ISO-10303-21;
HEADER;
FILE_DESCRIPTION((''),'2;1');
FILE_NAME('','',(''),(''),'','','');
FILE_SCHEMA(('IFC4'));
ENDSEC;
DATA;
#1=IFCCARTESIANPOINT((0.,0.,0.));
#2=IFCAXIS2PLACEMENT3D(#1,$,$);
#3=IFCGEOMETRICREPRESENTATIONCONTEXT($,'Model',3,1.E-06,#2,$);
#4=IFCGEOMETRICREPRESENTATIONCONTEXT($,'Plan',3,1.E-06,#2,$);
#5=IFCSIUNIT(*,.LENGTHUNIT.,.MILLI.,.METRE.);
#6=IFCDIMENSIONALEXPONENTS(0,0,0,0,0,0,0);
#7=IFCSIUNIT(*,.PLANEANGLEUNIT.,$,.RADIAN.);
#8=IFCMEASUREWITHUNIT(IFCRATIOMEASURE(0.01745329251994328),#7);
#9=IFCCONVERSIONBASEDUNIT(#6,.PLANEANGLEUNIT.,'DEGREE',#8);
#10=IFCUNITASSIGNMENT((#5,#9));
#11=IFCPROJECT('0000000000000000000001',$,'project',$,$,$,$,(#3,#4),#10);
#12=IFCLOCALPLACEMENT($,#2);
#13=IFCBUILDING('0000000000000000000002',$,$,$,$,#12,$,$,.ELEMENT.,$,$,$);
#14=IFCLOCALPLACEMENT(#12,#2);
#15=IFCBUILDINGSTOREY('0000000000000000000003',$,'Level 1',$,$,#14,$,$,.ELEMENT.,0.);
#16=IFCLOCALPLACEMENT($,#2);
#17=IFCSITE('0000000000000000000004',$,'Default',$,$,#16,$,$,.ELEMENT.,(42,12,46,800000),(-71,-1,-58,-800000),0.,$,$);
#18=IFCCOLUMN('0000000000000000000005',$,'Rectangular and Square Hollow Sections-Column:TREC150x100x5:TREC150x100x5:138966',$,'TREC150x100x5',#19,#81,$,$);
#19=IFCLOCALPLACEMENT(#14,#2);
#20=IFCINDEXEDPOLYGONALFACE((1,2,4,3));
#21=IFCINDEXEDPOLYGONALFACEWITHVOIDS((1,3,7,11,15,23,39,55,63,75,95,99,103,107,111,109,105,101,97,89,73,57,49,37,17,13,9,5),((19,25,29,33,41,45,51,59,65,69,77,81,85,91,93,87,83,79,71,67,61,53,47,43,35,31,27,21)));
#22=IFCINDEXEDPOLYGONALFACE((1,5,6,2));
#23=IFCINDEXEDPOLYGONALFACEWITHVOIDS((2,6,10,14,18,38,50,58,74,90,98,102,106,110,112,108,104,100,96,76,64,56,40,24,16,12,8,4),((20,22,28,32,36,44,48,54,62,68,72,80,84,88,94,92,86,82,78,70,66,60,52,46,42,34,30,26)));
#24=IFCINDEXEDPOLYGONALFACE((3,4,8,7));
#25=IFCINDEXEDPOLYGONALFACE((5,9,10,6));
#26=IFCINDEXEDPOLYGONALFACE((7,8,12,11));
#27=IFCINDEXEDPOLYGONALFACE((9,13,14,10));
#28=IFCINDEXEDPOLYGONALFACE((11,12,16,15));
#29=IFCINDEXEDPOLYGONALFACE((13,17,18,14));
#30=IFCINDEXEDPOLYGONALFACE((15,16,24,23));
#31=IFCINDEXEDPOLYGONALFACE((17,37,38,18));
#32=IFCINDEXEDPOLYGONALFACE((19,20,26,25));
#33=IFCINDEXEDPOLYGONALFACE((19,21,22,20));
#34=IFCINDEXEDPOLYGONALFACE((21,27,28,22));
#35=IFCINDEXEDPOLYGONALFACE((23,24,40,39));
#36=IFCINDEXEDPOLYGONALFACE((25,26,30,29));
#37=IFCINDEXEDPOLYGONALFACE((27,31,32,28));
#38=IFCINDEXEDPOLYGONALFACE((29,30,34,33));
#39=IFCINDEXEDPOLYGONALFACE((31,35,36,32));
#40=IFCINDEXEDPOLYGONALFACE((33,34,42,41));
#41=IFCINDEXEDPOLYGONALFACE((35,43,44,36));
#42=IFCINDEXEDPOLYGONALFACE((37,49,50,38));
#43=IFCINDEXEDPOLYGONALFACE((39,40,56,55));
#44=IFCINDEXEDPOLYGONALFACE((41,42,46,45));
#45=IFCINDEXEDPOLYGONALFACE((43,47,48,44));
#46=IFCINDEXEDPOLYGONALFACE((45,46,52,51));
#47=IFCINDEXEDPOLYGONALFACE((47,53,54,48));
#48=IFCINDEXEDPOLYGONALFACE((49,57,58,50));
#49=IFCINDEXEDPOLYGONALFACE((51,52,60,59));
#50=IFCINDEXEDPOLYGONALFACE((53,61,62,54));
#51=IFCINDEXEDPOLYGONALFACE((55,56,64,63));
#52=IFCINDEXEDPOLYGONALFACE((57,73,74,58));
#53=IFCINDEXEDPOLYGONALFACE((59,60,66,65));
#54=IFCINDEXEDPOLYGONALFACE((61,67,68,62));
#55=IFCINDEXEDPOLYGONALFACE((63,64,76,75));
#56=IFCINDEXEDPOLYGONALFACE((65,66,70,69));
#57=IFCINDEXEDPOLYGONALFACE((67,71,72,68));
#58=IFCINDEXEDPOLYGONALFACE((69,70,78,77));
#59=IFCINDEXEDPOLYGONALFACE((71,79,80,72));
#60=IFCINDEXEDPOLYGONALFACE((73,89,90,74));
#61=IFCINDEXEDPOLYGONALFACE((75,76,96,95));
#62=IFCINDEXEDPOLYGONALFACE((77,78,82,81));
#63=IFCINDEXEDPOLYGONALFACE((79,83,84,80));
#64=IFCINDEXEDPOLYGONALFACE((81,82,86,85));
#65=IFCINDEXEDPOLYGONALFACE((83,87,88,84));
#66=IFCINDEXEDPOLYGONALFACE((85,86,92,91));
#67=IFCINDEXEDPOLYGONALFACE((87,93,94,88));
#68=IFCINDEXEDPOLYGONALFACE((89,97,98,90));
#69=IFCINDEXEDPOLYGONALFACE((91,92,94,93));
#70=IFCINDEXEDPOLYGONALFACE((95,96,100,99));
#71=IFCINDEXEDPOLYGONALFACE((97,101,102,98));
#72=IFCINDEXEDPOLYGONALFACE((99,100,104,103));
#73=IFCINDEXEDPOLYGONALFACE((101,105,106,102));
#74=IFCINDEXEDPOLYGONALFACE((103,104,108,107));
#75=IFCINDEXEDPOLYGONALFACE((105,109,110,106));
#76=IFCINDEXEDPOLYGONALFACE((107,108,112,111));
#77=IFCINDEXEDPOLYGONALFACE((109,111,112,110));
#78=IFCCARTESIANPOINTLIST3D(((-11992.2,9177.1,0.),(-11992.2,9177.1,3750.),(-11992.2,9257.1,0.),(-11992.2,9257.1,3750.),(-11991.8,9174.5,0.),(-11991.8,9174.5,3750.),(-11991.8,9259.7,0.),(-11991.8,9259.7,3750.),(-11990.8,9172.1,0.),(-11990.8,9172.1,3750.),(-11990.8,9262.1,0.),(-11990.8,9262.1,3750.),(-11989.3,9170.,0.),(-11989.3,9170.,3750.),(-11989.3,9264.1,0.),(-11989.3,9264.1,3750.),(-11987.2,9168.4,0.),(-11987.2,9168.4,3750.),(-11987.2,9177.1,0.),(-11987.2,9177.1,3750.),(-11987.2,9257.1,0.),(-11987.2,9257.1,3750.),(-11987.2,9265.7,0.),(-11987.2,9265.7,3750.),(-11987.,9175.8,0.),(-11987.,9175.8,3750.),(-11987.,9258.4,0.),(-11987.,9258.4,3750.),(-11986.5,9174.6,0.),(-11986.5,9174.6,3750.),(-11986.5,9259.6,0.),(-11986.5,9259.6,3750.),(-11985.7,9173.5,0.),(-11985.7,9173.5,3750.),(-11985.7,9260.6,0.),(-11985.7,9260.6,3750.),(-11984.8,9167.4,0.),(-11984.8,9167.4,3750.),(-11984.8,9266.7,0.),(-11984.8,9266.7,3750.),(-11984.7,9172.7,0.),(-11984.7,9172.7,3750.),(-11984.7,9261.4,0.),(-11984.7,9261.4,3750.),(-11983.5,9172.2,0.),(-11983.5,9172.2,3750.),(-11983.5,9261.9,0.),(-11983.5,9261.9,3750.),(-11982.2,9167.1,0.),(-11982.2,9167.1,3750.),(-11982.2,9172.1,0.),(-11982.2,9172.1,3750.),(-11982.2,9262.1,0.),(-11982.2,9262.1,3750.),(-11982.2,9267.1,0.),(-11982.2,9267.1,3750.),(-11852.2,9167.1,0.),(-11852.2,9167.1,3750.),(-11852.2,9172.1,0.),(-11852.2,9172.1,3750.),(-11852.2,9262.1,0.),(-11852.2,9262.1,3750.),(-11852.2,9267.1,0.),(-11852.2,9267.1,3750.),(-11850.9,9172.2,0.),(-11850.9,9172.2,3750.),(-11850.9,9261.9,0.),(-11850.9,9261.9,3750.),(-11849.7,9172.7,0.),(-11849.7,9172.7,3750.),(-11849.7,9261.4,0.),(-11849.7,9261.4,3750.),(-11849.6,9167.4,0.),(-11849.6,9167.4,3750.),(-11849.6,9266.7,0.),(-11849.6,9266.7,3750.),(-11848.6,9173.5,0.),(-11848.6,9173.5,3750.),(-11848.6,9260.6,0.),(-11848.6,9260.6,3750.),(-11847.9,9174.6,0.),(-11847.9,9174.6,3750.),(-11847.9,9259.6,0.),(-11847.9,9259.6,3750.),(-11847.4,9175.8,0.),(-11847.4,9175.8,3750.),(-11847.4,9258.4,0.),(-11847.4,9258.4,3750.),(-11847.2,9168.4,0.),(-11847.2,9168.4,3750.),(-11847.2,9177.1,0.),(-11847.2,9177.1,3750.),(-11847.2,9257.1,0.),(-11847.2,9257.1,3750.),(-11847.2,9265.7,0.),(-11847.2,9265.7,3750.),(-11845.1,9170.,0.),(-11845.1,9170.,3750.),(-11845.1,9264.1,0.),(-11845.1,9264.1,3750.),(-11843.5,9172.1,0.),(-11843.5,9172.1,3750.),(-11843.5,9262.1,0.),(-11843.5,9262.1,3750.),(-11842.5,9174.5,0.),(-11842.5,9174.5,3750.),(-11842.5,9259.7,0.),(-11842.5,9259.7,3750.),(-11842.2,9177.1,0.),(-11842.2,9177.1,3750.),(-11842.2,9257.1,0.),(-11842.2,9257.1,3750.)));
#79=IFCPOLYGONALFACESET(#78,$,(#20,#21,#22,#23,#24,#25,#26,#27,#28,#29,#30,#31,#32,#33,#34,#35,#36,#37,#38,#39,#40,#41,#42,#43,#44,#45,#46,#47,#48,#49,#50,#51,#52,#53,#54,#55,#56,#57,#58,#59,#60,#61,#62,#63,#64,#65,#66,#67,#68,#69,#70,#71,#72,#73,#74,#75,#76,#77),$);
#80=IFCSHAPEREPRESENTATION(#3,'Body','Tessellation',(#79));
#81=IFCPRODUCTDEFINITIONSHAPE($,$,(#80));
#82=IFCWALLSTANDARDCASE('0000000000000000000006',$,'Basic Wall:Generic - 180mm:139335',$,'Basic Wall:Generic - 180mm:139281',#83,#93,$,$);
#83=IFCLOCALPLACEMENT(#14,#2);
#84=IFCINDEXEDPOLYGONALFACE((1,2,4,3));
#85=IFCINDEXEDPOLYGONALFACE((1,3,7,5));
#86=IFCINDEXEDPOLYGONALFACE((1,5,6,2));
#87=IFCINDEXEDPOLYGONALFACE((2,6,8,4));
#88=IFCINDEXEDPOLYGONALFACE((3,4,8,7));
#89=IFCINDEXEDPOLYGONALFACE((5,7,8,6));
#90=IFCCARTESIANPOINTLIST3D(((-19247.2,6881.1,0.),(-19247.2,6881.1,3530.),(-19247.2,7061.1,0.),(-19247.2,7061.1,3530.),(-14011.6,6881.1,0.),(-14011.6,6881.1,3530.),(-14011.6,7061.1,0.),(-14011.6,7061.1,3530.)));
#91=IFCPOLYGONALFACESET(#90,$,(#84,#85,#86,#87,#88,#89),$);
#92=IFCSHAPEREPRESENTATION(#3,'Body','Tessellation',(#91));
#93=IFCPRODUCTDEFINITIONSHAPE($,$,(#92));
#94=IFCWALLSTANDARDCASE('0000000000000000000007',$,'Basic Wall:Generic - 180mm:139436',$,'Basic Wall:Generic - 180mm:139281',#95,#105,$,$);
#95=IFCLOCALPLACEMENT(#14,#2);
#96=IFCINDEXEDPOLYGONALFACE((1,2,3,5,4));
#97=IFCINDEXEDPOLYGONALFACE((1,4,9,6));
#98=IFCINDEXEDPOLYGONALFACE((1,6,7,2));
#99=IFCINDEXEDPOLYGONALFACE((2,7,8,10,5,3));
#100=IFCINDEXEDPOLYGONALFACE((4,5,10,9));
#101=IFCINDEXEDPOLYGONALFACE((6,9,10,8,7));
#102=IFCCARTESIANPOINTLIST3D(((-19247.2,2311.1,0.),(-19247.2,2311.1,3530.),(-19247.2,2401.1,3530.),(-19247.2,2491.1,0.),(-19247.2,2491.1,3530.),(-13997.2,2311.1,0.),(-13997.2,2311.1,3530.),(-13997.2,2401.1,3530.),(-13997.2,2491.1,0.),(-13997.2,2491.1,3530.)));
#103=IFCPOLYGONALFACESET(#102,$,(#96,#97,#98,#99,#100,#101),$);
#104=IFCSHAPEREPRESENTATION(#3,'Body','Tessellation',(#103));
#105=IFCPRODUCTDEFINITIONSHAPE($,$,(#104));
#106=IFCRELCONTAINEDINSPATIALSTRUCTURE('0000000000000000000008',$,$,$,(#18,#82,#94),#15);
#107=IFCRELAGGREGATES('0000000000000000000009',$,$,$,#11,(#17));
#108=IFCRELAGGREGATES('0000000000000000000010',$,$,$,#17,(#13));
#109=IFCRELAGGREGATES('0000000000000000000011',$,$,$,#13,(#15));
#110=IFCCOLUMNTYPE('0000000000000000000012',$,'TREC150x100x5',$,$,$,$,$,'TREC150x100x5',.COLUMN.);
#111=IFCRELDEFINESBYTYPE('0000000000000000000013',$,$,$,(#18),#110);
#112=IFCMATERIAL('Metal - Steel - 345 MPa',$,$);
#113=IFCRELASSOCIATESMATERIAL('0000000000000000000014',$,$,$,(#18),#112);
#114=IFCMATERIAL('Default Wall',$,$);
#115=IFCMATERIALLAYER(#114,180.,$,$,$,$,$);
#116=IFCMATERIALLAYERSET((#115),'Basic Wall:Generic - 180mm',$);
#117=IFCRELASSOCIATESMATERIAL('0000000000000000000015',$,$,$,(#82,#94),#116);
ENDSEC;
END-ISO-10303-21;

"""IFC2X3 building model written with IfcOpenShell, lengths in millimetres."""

from ifc_helpers import new_model, entity, si_unit, converted_unit, frame, frame_2d, origin, place, context, project, spatial, polyline, circle_curve, parameter, trimmed, segment, composite_curve, rectangle, outline, extrude, clip, bounded_halfspace, source, transform, mapped, material, layer, layer_set, layer_usage, type_object, type_shapes, element, save


model = new_model("IFC2X3")

# Units and contexts
model_context = context("Model", 3, precision=1e-06, world=origin())
plan_context = context("Plan", 3, precision=1e-06, world=origin())
ifc_project = project(units=[si_unit("LENGTHUNIT", "METRE", prefix="MILLI"), converted_unit("PLANEANGLEUNIT", "DEGREE", entity("IfcRatioMeasure", 0.01745329251994328), si_unit("PLANEANGLEUNIT", "RADIAN"), dimensions=[0, 0, 0, 0, 0, 0, 0])], contexts=[model_context, plan_context])

# Site, building, storey
site_placement = place(None, origin())
site = spatial("IfcSite", under=ifc_project, at=site_placement, Name="Default", CompositionType="ELEMENT", RefLatitude=(42, 12, 46, 800000), RefLongitude=(-71, -1, -58, -800000), RefElevation=0.0)
building_placement = place(None, origin())
building = spatial("IfcBuilding", under=site, at=building_placement, CompositionType="ELEMENT")
storey_placement = place(building_placement, origin())
storey = spatial("IfcBuildingStorey", under=building, at=storey_placement, Name="Level 1", CompositionType="ELEMENT", Elevation=0.0)

# Column
ifc_material_1 = material(Name="Metal - Steel - 345 MPa")
column_type_1 = type_object("IfcColumnType", Name="TREC150x100x5", ElementType="TREC150x100x5", PredefinedType="COLUMN")
shared_shape_1 = source(origin(), model_context, "Body", "SweptSolid", [
    extrude(outline(composite_curve([segment(polyline([(-40.0, -75.0), (40.0, -75.0)]), True, "CONTINUOUS"), segment(trimmed(circle_curve(frame_2d((40.0, -65.0), x_axis=(-1.0, 0.0)), 10.0), [parameter(90.0)], [parameter(180.0)], True, "PARAMETER"), True, "CONTINUOUS"), segment(polyline([(50.0, -65.0), (50.0, 65.0)]), True, "CONTINUOUS"), segment(trimmed(circle_curve(frame_2d((40.0, 65.0), x_axis=(-1.0, 0.0)), 10.0), [parameter(180.0)], [parameter(270.0)], True, "PARAMETER"), True, "CONTINUOUS"), segment(polyline([(40.0, 75.0), (-40.0, 75.0)]), True, "CONTINUOUS"), segment(trimmed(circle_curve(frame_2d((-40.0, 65.0), x_axis=(-1.0, 0.0)), 10.0), [parameter(270.0)], [parameter(360.0)], True, "PARAMETER"), True, "CONTINUOUS"), segment(polyline([(-50.0, 65.0), (-50.0, -65.0)]), True, "CONTINUOUS"), segment(trimmed(circle_curve(frame_2d((-40.0, -65.0), x_axis=(-1.0, 0.0)), 10.0), [parameter(360.0)], [parameter(90.0)], True, "PARAMETER"), True, "CONTINUOUS")], self_intersect=False), holes=[composite_curve([segment(trimmed(circle_curve(frame_2d((-40.0, -65.0), x_axis=(-1.0, 0.0)), 5.0), [parameter(0.0)], [parameter(90.0)], True, "PARAMETER"), False, "CONTINUOUS"), segment(polyline([(-45.0, -65.0), (-45.0, 65.0)]), True, "CONTINUOUS"), segment(trimmed(circle_curve(frame_2d((-40.0, 65.0), x_axis=(-1.0, 0.0)), 5.0), [parameter(270.0)], [parameter(360.0)], True, "PARAMETER"), False, "CONTINUOUS"), segment(polyline([(-40.0, 70.0), (40.0, 70.0)]), True, "CONTINUOUS"), segment(trimmed(circle_curve(frame_2d((40.0, 65.0), x_axis=(-1.0, 0.0)), 5.0), [parameter(180.0)], [parameter(270.0)], True, "PARAMETER"), False, "CONTINUOUS"), segment(polyline([(45.0, 65.0), (45.0, -65.0)]), True, "CONTINUOUS"), segment(trimmed(circle_curve(frame_2d((40.0, -65.0), x_axis=(-1.0, 0.0)), 5.0), [parameter(90.0)], [parameter(180.0)], True, "PARAMETER"), False, "CONTINUOUS"), segment(polyline([(40.0, -70.0), (-40.0, -70.0)]), True, "CONTINUOUS")], self_intersect=False)]), frame((0.0, 0.0, 0.0), z_axis=(0.0, 0.0, 1.0), x_axis=(-1.0, 0.0, 0.0)), (0.0, 0.0, 1.0), 3750.0),
])
type_shapes(column_type_1, [shared_shape_1])
for number, where, z_axis, x_axis, name in (
    (1, (-11917.2, 9217.1, 0.0), (0.0, 0.0, 1.0), (0.0, 1.0, 0.0), "Rectangular and Square Hollow Sections-Column:TREC150x100x5:TREC150x100x5:138966"),
):
    element("IfcColumn", number, at=place(storey_placement, frame(where, z_axis=z_axis, x_axis=x_axis)), inside=storey, type_object=column_type_1, material=ifc_material_1, Name=name, ObjectType="TREC150x100x5", context=model_context, shape_type="MappedRepresentation", body=[
        mapped(shared_shape_1, transform((0.0, 0.0, 0.0), scale=1.0)),
    ])

# Walls
ifc_material_2 = material(Name="Default Wall")
ifc_layer = layer(ifc_material_2, 180.0)
ifc_layer_set = layer_set([ifc_layer], Name="Basic Wall:Generic - 180mm")
ifc_layer_usage_1 = layer_usage(ifc_layer_set, "AXIS2", "POSITIVE", -90.0)
wall_1_placement = place(storey_placement, frame((-19247.2, 6971.1, 0.0)))
element("IfcWallStandardCase", 2, at=wall_1_placement, inside=storey, material=ifc_layer_usage_1, Name="Basic Wall:Generic - 180mm:139335", ObjectType="Basic Wall:Generic - 180mm:139281", context=model_context, shape_type="Clipping", body=[
    clip(extrude(rectangle(XDim=5235.6, YDim=180.0, at=frame_2d((2617.8, 0.0), x_axis=(-1.0, 0.0))), origin(), (0.0, 0.0, 1.0), 3750.0), bounded_halfspace(frame((0.0, -90.0, 3530.0), z_axis=(0.0, 0.0, 1.0), x_axis=(0.0, 1.0, 0.0)), False, frame((0.0, -90.0, 3530.0)), polyline([(0.0, 0.0), (5235.6, 0.0), (5235.6, 90.0), (5235.6, 180.0), (0.0, 180.0), (0.0, 90.0), (0.0, 0.0)]))),
])
ifc_layer_usage_2 = layer_usage(ifc_layer_set, "AXIS2", "POSITIVE", -90.0)
wall_2_placement = place(storey_placement, frame((-13997.2, 2401.1, 0.0), z_axis=(0.0, 0.0, 1.0), x_axis=(-1.0, 0.0, 0.0)))
element("IfcWallStandardCase", 3, at=wall_2_placement, inside=storey, material=ifc_layer_usage_2, Name="Basic Wall:Generic - 180mm:139436", ObjectType="Basic Wall:Generic - 180mm:139281", context=model_context, shape_type="Clipping", body=[
    clip(clip(clip(extrude(rectangle(XDim=5250.0, YDim=180.0, at=frame_2d((2625.0, 0.0), x_axis=(-1.0, 0.0))), origin(), (0.0, 0.0, 1.0), 3750.0), bounded_halfspace(frame((0.0, -90.0, 3530.0), z_axis=(0.0, 0.0, -1.0), x_axis=(0.0, 1.0, 0.0)), True, frame((0.0, -90.0, 3530.0)), polyline([(0.0, 0.0), (5250.0, 0.0), (5250.0, 90.0), (0.0, 90.0), (0.0, 0.0)]))), bounded_halfspace(frame((0.0, -90.0, 3530.0), z_axis=(0.0, 0.0, -1.0), x_axis=(0.0, 1.0, 0.0)), True, frame((0.0, -90.0, 3530.0)), polyline([(0.0, 0.0), (5250.0, 0.0), (5250.0, 90.0), (0.0, 90.0), (0.0, 0.0)]))), bounded_halfspace(frame((5250.0, 0.0, 3530.0), z_axis=(0.0, 0.0, 1.0), x_axis=(0.0, 1.0, 0.0)), False, frame((5250.0, 0.0, 3530.0)), polyline([(0.0, 0.0), (0.0, 90.0), (-5250.0, 90.0), (-5250.0, 0.0), (0.0, 0.0)]))),
])

save(model, "model.ifc")
